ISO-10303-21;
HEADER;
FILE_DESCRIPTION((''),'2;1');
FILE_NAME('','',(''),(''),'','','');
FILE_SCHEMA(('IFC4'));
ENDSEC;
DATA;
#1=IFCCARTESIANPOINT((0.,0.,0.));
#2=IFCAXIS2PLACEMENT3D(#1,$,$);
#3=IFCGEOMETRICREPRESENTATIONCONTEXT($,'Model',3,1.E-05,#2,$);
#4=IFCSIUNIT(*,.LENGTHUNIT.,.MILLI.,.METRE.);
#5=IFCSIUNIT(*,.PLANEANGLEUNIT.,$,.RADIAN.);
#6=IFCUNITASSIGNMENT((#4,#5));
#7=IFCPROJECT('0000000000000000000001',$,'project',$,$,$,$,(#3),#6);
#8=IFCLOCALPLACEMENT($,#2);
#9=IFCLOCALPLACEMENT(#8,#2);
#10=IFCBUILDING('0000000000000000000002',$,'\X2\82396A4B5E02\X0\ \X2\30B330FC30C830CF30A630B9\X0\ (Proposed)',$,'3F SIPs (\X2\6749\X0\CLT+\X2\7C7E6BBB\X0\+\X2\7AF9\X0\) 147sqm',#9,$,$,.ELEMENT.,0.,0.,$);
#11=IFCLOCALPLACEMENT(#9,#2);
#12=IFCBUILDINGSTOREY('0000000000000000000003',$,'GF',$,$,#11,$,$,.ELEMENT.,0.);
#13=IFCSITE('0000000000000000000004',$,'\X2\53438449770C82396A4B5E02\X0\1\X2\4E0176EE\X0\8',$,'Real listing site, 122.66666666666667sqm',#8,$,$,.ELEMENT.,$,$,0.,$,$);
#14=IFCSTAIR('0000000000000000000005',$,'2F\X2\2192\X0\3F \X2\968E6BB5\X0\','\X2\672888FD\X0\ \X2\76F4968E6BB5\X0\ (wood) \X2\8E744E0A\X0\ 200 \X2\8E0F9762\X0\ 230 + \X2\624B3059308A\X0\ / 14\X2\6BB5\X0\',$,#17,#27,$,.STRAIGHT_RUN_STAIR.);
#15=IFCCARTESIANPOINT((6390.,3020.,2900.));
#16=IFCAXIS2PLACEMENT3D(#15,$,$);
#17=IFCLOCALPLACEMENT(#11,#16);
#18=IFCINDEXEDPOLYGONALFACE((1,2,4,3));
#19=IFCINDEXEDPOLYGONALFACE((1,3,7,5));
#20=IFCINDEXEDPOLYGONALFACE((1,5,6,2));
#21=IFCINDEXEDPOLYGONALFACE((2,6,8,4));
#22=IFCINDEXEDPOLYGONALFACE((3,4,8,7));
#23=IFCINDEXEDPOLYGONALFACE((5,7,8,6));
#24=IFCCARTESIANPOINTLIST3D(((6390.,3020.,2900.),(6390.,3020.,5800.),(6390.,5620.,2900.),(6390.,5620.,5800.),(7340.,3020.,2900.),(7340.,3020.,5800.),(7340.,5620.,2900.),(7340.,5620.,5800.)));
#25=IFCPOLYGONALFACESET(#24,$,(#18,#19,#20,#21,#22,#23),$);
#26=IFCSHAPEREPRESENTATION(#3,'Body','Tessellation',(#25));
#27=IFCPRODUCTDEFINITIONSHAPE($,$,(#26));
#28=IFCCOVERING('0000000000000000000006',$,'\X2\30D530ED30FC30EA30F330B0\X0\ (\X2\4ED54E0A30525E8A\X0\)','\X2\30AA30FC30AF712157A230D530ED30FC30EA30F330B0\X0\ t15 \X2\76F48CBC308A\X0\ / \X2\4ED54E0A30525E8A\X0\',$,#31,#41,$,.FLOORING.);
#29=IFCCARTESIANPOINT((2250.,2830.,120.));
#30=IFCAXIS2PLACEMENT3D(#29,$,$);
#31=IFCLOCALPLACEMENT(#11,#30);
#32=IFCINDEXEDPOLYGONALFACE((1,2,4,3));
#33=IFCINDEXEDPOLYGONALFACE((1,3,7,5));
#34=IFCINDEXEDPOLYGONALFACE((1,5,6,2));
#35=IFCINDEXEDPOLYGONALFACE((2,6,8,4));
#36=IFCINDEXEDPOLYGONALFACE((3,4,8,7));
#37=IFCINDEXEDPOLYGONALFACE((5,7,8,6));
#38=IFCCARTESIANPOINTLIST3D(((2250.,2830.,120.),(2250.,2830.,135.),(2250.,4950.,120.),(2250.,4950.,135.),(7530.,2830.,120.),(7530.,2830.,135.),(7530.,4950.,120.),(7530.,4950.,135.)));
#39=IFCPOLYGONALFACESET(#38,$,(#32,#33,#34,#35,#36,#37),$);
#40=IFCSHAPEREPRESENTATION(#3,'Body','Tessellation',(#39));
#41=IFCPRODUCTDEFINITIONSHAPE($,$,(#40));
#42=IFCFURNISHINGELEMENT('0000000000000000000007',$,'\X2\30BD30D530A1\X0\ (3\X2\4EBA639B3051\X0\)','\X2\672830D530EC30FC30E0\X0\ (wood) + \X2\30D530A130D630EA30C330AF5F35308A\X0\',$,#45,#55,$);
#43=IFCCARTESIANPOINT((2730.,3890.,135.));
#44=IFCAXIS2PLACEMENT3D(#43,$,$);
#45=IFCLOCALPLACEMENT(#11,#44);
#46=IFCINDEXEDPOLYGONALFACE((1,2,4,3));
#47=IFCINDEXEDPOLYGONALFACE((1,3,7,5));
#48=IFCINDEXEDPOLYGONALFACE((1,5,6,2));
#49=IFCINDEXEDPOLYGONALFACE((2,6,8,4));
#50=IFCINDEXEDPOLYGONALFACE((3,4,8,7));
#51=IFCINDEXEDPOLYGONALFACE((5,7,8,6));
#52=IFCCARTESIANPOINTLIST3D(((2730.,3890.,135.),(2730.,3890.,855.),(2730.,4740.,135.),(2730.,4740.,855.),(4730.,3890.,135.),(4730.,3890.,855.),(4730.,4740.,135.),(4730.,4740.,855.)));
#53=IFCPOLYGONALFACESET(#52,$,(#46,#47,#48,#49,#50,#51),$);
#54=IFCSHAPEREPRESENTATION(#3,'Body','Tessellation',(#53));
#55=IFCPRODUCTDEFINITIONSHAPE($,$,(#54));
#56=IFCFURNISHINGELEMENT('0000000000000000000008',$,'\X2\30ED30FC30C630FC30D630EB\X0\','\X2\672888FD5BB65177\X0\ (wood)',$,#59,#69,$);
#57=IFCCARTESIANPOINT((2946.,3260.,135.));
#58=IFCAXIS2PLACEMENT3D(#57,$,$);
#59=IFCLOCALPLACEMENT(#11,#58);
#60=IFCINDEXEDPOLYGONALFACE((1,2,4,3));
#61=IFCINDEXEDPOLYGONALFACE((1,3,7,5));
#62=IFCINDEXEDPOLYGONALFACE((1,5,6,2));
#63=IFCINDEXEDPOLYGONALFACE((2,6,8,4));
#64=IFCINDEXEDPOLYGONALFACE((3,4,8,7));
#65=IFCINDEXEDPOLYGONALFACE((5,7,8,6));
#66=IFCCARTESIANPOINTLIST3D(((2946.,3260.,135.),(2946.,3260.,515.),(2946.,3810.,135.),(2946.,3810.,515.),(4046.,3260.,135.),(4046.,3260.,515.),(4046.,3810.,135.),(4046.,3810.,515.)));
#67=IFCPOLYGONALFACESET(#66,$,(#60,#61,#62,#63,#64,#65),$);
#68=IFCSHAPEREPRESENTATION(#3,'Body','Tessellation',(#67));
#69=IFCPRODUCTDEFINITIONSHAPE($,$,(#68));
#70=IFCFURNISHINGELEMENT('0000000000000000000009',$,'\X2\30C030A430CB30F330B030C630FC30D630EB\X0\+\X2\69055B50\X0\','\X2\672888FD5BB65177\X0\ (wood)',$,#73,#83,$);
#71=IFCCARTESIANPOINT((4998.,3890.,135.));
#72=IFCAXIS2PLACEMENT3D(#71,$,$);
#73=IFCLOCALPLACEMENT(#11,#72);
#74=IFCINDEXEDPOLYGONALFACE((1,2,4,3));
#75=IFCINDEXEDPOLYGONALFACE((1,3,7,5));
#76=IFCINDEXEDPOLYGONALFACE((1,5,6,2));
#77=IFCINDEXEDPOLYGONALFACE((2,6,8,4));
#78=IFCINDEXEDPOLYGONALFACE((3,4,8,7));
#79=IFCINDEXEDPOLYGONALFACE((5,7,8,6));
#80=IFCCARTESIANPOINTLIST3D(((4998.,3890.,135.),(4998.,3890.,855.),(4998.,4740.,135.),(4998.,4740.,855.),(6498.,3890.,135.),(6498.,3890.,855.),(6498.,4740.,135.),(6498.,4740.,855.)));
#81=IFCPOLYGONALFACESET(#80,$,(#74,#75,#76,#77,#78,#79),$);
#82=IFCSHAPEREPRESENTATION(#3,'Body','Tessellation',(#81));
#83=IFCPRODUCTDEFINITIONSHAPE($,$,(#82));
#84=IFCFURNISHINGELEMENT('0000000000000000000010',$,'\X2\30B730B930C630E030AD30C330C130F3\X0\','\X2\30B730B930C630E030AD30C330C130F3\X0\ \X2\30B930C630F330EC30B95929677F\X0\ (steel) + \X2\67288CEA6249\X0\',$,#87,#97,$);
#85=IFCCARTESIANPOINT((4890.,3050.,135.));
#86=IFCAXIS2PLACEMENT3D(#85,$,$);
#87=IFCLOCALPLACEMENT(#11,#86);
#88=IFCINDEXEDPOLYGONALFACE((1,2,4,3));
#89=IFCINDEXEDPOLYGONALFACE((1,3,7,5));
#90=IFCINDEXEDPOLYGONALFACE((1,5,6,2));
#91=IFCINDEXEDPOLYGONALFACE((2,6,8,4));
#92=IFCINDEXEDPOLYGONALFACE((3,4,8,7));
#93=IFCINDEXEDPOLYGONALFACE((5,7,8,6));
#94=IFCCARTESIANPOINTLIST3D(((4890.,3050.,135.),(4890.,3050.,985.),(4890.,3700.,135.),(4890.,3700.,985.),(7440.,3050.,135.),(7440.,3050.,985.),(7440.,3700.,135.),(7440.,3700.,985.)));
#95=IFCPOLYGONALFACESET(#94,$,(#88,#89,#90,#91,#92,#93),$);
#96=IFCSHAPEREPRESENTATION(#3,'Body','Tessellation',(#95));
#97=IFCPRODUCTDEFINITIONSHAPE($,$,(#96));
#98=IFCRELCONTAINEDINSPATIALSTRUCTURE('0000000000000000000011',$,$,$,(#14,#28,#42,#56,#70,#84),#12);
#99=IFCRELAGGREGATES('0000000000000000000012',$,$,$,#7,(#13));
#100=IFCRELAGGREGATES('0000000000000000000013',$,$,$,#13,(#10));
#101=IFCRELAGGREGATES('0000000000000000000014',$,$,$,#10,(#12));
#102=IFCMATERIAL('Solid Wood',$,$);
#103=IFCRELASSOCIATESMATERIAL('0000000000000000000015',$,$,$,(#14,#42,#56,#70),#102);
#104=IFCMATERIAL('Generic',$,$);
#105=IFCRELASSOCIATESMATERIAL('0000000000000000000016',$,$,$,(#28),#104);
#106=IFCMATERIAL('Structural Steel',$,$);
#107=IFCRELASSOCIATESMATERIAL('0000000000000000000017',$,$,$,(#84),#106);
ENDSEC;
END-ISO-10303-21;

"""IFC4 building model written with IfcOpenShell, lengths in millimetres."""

from ifc_helpers import new_model, si_unit, frame, frame_2d, origin, place, context, project, spatial, rectangle, extrude, material, element, save


model = new_model("IFC4")

# Units and contexts
model_context = context("Model", 3, precision=1e-05, world=origin())
ifc_project = project(units=[si_unit("LENGTHUNIT", "METRE", prefix="MILLI"), si_unit("PLANEANGLEUNIT", "RADIAN")], contexts=[model_context])

# Site, building, storey
site_placement = place(None, origin())
site = spatial("IfcSite", under=ifc_project, at=site_placement, Name="千葉県船橋市1丁目8", ObjectType="Real listing site, 122.66666666666667sqm", CompositionType="ELEMENT", RefElevation=0.0)
building_placement = place(site_placement, origin())
building = spatial("IfcBuilding", under=site, at=building_placement, Name="船橋市 コートハウス (Proposed)", ObjectType="3F SIPs (杉CLT+籾殻+竹) 147sqm", CompositionType="ELEMENT", ElevationOfRefHeight=0.0, ElevationOfTerrain=0.0)
storey_placement = place(building_placement, origin())
storey = spatial("IfcBuildingStorey", under=building, at=storey_placement, Name="GF", CompositionType="ELEMENT", Elevation=0.0)

# Shared definitions
ifc_material_1 = material(Name="Solid Wood")
ifc_material_2 = material(Name="Generic")

# Stair
stair_1_placement = place(storey_placement, frame((6390.0, 3020.0, 2900.0)))
element("IfcStair", 1, at=stair_1_placement, inside=storey, material=ifc_material_1, Name="2F→3F 階段", Description="木製 直階段 (wood) 蹴上 200 踏面 230 + 手すり / 14段", PredefinedType="STRAIGHT_RUN_STAIR", context=model_context, shape_type="SweptSolid", body=[
    extrude(rectangle(XDim=950.0, YDim=2600.0, at=frame_2d((475.0, 1300.0))), frame((6390.0, 3020.0, 2900.0)), (0.0, 0.0, 1.0), 2900.0),
])

# Covering
covering_placement = place(storey_placement, frame((2250.0, 2830.0, 120.0)))
element("IfcCovering", 2, at=covering_placement, inside=storey, material=ifc_material_2, Name="フローリング (仕上げ床)", Description="オーク無垢フローリング t15 直貼り / 仕上げ床", PredefinedType="FLOORING", context=model_context, shape_type="SweptSolid", body=[
    extrude(rectangle(XDim=5280.0, YDim=2120.0, at=frame_2d((2640.0, 1060.0))), frame((2250.0, 2830.0, 120.0)), (0.0, 0.0, 1.0), 15.0),
])

# Furnishing elements
furnishing_1_placement = place(storey_placement, frame((2730.0, 3890.0, 135.0)))
element("IfcFurnishingElement", 3, at=furnishing_1_placement, inside=storey, material=ifc_material_1, Name="ソファ (3人掛け)", Description="木フレーム (wood) + ファブリック張り", context=model_context, shape_type="SweptSolid", body=[
    extrude(rectangle(XDim=2000.0, YDim=850.0, at=frame_2d((1000.0, 425.0))), frame((2730.0, 3890.0, 135.0)), (0.0, 0.0, 1.0), 720.0),
])
furnishing_2_placement = place(storey_placement, frame((2946.0, 3260.0, 135.0)))
element("IfcFurnishingElement", 4, at=furnishing_2_placement, inside=storey, material=ifc_material_1, Name="ローテーブル", Description="木製家具 (wood)", context=model_context, shape_type="SweptSolid", body=[
    extrude(rectangle(XDim=1100.0, YDim=550.0, at=frame_2d((550.0, 275.0))), frame((2946.0, 3260.0, 135.0)), (0.0, 0.0, 1.0), 380.0),
])
furnishing_3_placement = place(storey_placement, frame((4998.0, 3890.0, 135.0)))
element("IfcFurnishingElement", 5, at=furnishing_3_placement, inside=storey, material=ifc_material_1, Name="ダイニングテーブル+椅子", Description="木製家具 (wood)", context=model_context, shape_type="SweptSolid", body=[
    extrude(rectangle(XDim=1500.0, YDim=850.0, at=frame_2d((750.0, 425.0))), frame((4998.0, 3890.0, 135.0)), (0.0, 0.0, 1.0), 720.0),
])
ifc_material_3 = material(Name="Structural Steel")
furnishing_4_placement = place(storey_placement, frame((4890.0, 3050.0, 135.0)))
element("IfcFurnishingElement", 6, at=furnishing_4_placement, inside=storey, material=ifc_material_3, Name="システムキッチン", Description="システムキッチン ステンレス天板 (steel) + 木質扉", context=model_context, shape_type="SweptSolid", body=[
    extrude(rectangle(XDim=2550.0, YDim=650.0, at=frame_2d((1275.0, 325.0))), frame((4890.0, 3050.0, 135.0)), (0.0, 0.0, 1.0), 850.0),
])

save(model, "model.ifc")
